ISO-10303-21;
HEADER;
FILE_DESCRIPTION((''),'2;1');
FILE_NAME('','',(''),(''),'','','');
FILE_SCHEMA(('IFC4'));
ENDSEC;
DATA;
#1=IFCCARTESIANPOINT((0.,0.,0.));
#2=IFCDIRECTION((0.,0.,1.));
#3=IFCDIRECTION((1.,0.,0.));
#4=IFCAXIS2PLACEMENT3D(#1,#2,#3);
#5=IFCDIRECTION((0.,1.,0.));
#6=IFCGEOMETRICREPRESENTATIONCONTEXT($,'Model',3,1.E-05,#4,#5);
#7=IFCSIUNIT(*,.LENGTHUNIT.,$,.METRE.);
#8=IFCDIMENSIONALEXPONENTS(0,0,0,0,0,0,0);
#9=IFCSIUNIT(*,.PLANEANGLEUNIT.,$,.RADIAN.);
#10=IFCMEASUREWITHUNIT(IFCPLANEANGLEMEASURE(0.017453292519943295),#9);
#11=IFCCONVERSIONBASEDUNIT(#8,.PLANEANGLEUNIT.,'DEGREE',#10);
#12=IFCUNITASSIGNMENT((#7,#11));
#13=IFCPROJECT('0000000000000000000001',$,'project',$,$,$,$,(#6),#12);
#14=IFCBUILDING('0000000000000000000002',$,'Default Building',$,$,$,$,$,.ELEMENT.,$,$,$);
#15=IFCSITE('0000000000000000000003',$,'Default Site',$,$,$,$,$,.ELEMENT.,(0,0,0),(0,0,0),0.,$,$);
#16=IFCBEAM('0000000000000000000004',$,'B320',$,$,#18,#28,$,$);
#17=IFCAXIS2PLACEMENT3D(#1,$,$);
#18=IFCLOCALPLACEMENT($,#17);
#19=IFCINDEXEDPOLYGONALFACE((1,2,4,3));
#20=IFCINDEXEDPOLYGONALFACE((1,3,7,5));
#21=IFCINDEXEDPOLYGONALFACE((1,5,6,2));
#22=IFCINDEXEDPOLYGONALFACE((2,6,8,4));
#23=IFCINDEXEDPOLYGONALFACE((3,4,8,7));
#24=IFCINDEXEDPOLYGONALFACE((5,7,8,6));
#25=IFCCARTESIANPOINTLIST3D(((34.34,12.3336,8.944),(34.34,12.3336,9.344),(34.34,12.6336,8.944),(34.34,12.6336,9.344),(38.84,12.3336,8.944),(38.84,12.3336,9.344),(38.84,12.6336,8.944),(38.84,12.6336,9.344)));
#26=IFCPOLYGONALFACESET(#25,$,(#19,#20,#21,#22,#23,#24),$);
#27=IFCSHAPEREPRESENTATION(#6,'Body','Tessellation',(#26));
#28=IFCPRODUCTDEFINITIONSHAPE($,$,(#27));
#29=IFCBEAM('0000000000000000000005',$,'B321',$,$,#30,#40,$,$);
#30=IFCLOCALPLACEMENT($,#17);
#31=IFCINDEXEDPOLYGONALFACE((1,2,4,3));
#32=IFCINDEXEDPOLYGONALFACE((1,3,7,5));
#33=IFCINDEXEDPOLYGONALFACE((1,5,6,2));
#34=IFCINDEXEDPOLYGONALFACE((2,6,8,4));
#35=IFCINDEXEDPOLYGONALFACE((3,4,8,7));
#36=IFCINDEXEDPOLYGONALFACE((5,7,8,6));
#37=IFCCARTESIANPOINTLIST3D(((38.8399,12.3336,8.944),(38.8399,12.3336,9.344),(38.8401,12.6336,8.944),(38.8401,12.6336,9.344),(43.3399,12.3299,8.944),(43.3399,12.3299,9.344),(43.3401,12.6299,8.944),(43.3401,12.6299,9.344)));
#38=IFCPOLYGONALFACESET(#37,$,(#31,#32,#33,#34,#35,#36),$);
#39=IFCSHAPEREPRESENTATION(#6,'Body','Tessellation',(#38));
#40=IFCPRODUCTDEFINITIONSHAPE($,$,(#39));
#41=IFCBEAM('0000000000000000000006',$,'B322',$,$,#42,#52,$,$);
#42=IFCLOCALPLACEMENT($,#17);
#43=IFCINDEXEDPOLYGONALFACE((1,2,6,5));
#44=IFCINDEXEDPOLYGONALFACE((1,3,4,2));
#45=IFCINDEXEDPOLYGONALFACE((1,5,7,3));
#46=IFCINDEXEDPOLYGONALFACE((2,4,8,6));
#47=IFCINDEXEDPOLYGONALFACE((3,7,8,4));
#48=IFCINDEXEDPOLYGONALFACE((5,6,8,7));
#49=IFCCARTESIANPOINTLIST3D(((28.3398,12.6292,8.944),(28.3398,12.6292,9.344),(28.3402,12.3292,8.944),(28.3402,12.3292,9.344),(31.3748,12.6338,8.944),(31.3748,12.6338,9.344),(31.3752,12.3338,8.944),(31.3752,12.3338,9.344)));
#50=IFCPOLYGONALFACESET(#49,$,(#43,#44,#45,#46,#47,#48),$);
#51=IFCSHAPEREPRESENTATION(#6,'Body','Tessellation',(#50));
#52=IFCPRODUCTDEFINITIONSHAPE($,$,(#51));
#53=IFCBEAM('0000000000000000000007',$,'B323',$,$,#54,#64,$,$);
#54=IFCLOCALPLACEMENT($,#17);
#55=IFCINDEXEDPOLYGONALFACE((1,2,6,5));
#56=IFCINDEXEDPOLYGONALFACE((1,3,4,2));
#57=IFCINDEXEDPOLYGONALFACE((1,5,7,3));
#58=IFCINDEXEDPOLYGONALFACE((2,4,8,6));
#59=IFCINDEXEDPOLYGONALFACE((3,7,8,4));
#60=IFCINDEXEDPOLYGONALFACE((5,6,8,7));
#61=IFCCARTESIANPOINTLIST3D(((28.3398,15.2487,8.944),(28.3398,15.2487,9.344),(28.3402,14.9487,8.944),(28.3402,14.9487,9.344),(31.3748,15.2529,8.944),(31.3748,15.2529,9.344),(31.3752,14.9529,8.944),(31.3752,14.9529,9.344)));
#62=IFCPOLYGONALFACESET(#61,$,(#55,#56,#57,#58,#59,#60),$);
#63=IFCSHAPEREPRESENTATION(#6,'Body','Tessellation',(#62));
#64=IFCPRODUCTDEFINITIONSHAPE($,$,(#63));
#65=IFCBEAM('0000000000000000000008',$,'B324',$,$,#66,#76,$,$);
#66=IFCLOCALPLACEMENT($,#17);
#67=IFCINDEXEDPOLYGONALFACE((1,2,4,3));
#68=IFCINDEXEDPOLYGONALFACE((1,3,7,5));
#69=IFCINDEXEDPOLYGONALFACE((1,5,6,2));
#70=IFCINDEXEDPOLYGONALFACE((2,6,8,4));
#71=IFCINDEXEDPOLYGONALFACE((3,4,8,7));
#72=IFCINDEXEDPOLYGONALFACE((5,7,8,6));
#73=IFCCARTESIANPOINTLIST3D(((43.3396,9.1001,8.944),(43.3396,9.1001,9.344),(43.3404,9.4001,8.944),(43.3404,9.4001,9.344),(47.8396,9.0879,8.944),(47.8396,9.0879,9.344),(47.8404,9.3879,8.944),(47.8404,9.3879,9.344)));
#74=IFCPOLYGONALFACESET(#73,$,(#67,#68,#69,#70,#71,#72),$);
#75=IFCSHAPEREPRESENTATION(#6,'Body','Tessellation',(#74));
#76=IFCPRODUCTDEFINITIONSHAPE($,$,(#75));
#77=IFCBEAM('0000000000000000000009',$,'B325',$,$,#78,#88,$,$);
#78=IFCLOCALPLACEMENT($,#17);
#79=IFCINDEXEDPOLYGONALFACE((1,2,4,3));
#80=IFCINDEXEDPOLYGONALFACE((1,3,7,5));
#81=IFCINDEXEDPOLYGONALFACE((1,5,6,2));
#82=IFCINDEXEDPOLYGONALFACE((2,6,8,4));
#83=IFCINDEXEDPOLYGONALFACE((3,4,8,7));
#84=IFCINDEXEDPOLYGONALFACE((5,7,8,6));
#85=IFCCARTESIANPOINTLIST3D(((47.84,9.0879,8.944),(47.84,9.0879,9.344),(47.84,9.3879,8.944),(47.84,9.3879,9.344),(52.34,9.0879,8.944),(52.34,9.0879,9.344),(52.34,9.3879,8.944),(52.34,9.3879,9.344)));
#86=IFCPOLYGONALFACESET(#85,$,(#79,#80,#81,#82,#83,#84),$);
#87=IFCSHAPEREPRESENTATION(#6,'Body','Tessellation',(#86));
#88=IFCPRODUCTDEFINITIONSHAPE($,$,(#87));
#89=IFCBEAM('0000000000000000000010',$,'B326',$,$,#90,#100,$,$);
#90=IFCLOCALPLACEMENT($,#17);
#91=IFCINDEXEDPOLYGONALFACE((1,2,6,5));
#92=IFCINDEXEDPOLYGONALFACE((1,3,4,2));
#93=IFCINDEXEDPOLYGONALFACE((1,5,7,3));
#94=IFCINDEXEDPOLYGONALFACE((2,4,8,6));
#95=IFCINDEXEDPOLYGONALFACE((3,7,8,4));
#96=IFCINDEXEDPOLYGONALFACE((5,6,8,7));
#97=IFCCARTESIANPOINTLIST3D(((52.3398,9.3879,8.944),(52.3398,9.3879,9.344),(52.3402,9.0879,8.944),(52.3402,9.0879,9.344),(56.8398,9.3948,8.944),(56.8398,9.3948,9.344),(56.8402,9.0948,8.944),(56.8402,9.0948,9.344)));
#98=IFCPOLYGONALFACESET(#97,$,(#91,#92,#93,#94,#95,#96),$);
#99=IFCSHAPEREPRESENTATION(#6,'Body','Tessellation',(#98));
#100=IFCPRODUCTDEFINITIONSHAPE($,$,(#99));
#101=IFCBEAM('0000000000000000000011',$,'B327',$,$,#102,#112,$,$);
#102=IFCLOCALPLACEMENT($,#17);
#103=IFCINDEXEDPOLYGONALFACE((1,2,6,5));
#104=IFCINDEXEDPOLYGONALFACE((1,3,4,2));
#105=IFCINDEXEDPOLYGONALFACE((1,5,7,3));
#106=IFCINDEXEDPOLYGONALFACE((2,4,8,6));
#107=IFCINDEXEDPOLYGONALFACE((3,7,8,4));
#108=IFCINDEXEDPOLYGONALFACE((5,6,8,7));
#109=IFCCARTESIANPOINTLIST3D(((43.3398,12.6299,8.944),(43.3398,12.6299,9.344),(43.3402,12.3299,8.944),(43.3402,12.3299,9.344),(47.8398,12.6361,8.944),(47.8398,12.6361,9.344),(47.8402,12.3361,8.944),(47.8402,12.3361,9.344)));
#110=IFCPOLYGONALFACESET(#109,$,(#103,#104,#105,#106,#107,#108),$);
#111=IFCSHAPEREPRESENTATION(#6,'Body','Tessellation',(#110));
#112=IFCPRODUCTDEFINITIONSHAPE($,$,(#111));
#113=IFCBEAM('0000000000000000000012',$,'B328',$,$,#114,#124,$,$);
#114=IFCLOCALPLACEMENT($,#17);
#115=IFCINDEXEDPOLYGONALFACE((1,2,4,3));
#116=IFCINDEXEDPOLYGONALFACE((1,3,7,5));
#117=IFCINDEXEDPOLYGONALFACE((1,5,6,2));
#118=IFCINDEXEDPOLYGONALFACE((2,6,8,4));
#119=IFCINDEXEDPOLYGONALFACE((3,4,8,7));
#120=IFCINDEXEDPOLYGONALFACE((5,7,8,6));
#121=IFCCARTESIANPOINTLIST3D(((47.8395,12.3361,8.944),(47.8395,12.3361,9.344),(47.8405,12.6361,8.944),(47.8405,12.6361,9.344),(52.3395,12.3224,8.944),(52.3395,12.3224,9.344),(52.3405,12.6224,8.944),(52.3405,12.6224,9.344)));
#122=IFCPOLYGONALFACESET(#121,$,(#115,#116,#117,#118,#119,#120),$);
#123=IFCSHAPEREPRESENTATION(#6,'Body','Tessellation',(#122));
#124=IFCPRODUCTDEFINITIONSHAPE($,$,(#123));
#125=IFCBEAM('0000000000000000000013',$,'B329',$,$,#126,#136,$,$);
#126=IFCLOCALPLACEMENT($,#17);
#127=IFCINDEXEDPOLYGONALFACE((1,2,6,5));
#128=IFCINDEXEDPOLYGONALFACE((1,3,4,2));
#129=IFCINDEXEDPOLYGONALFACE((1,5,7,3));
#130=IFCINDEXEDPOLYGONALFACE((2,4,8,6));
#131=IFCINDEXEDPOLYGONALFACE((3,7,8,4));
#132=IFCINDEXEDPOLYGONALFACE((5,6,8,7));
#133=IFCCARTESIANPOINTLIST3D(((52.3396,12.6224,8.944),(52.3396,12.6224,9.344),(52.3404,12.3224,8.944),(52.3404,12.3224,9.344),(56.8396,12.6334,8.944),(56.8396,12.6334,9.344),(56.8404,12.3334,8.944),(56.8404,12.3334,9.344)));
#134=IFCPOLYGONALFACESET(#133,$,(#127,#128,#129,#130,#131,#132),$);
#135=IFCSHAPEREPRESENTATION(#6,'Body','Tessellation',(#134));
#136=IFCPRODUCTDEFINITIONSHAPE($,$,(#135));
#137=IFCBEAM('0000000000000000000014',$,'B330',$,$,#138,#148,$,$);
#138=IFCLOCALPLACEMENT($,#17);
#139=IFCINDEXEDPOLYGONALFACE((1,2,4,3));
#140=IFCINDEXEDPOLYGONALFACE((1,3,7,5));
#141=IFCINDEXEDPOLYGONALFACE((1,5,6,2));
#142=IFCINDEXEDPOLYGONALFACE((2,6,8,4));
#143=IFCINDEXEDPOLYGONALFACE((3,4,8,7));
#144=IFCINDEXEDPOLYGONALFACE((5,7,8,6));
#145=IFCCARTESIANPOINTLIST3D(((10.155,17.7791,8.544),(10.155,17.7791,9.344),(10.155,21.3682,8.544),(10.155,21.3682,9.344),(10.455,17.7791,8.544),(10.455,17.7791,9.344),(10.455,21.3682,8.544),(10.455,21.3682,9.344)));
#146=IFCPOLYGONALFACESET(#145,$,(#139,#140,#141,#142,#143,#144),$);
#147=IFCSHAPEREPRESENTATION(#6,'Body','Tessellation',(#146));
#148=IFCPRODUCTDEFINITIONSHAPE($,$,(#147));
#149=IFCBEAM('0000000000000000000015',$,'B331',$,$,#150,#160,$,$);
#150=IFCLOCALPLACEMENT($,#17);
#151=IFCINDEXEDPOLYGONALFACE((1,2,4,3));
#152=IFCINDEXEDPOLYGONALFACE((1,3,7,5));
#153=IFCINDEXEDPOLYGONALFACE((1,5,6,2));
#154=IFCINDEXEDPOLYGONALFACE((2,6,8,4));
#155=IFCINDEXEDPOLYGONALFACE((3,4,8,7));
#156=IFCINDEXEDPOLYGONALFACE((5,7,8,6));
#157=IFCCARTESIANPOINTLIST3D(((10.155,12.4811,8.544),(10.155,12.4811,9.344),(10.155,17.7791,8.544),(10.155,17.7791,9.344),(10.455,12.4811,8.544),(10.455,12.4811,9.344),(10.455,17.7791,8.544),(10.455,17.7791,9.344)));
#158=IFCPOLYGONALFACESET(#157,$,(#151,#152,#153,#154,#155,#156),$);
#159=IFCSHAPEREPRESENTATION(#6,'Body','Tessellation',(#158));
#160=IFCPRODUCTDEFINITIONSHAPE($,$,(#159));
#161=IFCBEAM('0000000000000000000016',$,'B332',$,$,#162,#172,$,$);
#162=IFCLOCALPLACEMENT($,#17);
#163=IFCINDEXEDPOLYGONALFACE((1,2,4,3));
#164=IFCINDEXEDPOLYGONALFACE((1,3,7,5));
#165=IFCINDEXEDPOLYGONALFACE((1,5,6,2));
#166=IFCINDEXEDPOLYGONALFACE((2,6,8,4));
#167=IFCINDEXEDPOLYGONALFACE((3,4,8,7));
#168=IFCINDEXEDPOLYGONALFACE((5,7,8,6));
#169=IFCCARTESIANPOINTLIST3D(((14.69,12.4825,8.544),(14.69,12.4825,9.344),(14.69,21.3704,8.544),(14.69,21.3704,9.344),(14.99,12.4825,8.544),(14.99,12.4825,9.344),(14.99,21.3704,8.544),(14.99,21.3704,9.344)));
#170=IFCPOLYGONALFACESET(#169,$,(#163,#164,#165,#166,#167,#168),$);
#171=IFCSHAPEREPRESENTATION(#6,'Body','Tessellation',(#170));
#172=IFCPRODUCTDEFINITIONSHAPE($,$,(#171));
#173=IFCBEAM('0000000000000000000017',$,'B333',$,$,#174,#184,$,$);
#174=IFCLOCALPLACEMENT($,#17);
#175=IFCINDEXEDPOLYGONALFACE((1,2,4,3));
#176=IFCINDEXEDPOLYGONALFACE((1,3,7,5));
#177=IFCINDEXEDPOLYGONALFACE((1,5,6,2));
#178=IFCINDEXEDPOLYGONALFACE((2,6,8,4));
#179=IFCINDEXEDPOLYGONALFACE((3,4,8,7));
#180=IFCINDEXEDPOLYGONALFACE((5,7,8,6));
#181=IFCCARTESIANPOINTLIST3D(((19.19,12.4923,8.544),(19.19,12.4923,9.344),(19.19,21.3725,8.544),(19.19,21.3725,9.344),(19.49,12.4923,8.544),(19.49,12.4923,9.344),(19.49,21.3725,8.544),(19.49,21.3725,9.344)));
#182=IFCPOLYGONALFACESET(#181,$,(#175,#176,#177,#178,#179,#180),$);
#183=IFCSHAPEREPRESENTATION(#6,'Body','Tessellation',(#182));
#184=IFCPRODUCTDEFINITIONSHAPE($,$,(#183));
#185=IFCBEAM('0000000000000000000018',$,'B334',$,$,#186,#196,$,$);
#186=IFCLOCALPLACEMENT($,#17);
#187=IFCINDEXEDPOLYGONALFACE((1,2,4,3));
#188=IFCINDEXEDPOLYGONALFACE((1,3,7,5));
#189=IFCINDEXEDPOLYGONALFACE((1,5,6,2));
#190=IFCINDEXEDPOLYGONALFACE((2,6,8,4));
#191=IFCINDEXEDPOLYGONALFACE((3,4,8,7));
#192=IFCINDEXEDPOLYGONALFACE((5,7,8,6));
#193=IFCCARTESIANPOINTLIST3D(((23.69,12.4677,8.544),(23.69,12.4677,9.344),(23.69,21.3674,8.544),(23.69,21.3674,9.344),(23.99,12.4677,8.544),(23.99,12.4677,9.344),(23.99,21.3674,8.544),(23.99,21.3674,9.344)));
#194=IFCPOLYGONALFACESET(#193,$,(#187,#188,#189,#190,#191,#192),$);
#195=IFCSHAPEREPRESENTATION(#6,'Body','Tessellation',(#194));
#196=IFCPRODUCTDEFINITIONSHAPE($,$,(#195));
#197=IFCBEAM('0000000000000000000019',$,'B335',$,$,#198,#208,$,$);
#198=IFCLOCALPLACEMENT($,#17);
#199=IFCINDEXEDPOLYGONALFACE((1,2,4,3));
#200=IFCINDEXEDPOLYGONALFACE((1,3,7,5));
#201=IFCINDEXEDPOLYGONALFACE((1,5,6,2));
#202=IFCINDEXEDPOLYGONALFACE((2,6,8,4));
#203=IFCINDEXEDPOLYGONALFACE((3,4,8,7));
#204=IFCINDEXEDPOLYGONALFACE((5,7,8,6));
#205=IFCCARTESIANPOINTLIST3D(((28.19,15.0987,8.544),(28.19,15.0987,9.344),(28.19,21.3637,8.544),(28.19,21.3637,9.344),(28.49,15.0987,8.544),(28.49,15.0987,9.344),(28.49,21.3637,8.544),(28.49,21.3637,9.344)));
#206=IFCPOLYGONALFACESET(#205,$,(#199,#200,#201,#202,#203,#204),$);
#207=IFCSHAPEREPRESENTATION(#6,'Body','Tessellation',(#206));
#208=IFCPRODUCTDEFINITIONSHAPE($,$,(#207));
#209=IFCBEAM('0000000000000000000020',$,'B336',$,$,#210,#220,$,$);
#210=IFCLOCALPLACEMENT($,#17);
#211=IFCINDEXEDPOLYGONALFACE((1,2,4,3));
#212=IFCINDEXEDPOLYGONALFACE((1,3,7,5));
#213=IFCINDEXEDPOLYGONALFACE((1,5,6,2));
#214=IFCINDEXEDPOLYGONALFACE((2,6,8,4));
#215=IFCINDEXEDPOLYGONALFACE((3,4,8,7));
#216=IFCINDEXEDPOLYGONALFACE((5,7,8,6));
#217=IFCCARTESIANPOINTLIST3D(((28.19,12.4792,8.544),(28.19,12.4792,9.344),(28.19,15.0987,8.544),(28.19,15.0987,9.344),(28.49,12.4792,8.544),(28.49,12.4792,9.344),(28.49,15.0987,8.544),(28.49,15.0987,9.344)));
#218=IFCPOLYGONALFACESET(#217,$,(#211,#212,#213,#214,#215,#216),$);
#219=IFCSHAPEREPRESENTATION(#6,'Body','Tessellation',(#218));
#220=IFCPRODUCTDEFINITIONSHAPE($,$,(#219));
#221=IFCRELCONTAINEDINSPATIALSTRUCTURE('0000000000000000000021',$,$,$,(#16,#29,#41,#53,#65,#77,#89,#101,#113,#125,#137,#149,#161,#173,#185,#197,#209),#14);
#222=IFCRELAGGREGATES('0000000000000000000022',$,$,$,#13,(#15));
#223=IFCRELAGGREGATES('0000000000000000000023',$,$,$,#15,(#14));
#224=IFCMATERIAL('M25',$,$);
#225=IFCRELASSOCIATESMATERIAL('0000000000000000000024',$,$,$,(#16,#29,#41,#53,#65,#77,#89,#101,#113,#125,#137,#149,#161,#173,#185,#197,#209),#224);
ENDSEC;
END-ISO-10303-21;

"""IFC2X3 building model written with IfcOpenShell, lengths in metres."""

from ifc_helpers import new_model, entity, si_unit, converted_unit, direction, frame, frame_2d, origin_with_axes, place, context, project, spatial, rectangle, extrude, material, element, save


model = new_model("IFC2X3")

# Units and contexts
model_context = context("Model", 3, precision=1e-05, world=origin_with_axes(), true_north=direction((0.0, 1.0, 0.0)))
ifc_project = project(units=[si_unit("LENGTHUNIT", "METRE"), converted_unit("PLANEANGLEUNIT", "DEGREE", entity("IfcPlaneAngleMeasure", 0.017453292519943295), si_unit("PLANEANGLEUNIT", "RADIAN"), dimensions=[0, 0, 0, 0, 0, 0, 0])], contexts=[model_context])

# Site, building
site = spatial("IfcSite", under=ifc_project, Name="Default Site", CompositionType="ELEMENT", RefLatitude=(0, 0, 0), RefLongitude=(0, 0, 0), RefElevation=0.0)
building = spatial("IfcBuilding", under=site, Name="Default Building", CompositionType="ELEMENT")

# Beams
ifc_material = material(Name="M25")
placement = place(None, origin_with_axes())
element("IfcBeam", 1, at=placement, inside=building, material=ifc_material, Name="B320", context=model_context, shape_type="SweptSolid", body=[
    extrude(rectangle(XDim=0.3, YDim=0.4, at=frame_2d((0.0, 0.0), x_axis=(0.0, 1.0, 0.0))), frame((34.34, 12.4836, 9.144), z_axis=(1.0, -0.000008, 0.0), x_axis=(0.0, 0.0, -1.0)), (0.0, 0.0, 1.0), 4.5),
])
element("IfcBeam", 2, at=placement, inside=building, material=ifc_material, Name="B321", context=model_context, shape_type="SweptSolid", body=[
    extrude(rectangle(XDim=0.3, YDim=0.4, at=frame_2d((0.0, 0.0), x_axis=(0.0, 1.0, 0.0))), frame((38.84, 12.4836, 9.144), z_axis=(1.0, -0.000826, 0.0), x_axis=(0.0, 0.0, -1.0)), (0.0, 0.0, 1.0), 4.5),
])
element("IfcBeam", 3, at=placement, inside=building, material=ifc_material, Name="B322", context=model_context, shape_type="SweptSolid", body=[
    extrude(rectangle(XDim=0.3, YDim=0.4, at=frame_2d((0.0, 0.0), x_axis=(0.0, 1.0, 0.0))), frame((28.34, 12.4792, 9.144), z_axis=(0.999999, 0.001542, 0.0), x_axis=(0.0, 0.0, -1.0)), (0.0, 0.0, 1.0), 3.035),
])
element("IfcBeam", 4, at=placement, inside=building, material=ifc_material, Name="B323", context=model_context, shape_type="SweptSolid", body=[
    extrude(rectangle(XDim=0.3, YDim=0.4, at=frame_2d((0.0, 0.0), x_axis=(0.0, 1.0, 0.0))), frame((31.375, 15.1029, 9.144), z_axis=(-0.999999, -0.001391, 0.0), x_axis=(0.0, 0.0, -1.0)), (0.0, 0.0, 1.0), 3.035),
])
element("IfcBeam", 5, at=placement, inside=building, material=ifc_material, Name="B324", context=model_context, shape_type="SweptSolid", body=[
    extrude(rectangle(XDim=0.3, YDim=0.4, at=frame_2d((0.0, 0.0), x_axis=(0.0, 1.0, 0.0))), frame((43.34, 9.2501, 9.144), z_axis=(0.999996, -0.002702, 0.0), x_axis=(0.0, 0.0, -1.0)), (0.0, 0.0, 1.0), 4.5),
])
element("IfcBeam", 6, at=placement, inside=building, material=ifc_material, Name="B325", context=model_context, shape_type="SweptSolid", body=[
    extrude(rectangle(XDim=0.3, YDim=0.4, at=frame_2d((0.0, 0.0), x_axis=(0.0, 1.0, 0.0))), frame((47.84, 9.2379, 9.144), z_axis=(1.0, 0.0, 0.0), x_axis=(0.0, 0.0, -1.0)), (0.0, 0.0, 1.0), 4.5),
])
element("IfcBeam", 7, at=placement, inside=building, material=ifc_material, Name="B326", context=model_context, shape_type="SweptSolid", body=[
    extrude(rectangle(XDim=0.3, YDim=0.4, at=frame_2d((0.0, 0.0), x_axis=(0.0, 1.0, 0.0))), frame((52.34, 9.2379, 9.144), z_axis=(0.999999, 0.001537, 0.0), x_axis=(0.0, 0.0, -1.0)), (0.0, 0.0, 1.0), 4.5),
])
element("IfcBeam", 8, at=placement, inside=building, material=ifc_material, Name="B327", context=model_context, shape_type="SweptSolid", body=[
    extrude(rectangle(XDim=0.3, YDim=0.4, at=frame_2d((0.0, 0.0), x_axis=(0.0, 1.0, 0.0))), frame((43.34, 12.4799, 9.144), z_axis=(0.999999, 0.001374, 0.0), x_axis=(0.0, 0.0, -1.0)), (0.0, 0.0, 1.0), 4.5),
])
element("IfcBeam", 9, at=placement, inside=building, material=ifc_material, Name="B328", context=model_context, shape_type="SweptSolid", body=[
    extrude(rectangle(XDim=0.3, YDim=0.4, at=frame_2d((0.0, 0.0), x_axis=(0.0, 1.0, 0.0))), frame((47.84, 12.4861, 9.144), z_axis=(0.999995, -0.003045, 0.0), x_axis=(0.0, 0.0, -1.0)), (0.0, 0.0, 1.0), 4.5),
])
element("IfcBeam", 10, at=placement, inside=building, material=ifc_material, Name="B329", context=model_context, shape_type="SweptSolid", body=[
    extrude(rectangle(XDim=0.3, YDim=0.4, at=frame_2d((0.0, 0.0), x_axis=(0.0, 1.0, 0.0))), frame((52.34, 12.4724, 9.144), z_axis=(0.999997, 0.002456, 0.0), x_axis=(0.0, 0.0, -1.0)), (0.0, 0.0, 1.0), 4.5),
])
element("IfcBeam", 11, at=placement, inside=building, material=ifc_material, Name="B330", context=model_context, shape_type="SweptSolid", body=[
    extrude(rectangle(XDim=0.3, YDim=0.8, at=frame_2d((0.0, 0.0), x_axis=(0.0, 1.0, 0.0))), frame((10.305, 21.3682, 8.944), z_axis=(0.0, -1.0, 0.0), x_axis=(0.0, 0.0, -1.0)), (0.0, 0.0, 1.0), 3.5891),
])
element("IfcBeam", 12, at=placement, inside=building, material=ifc_material, Name="B331", context=model_context, shape_type="SweptSolid", body=[
    extrude(rectangle(XDim=0.3, YDim=0.8, at=frame_2d((0.0, 0.0), x_axis=(0.0, 1.0, 0.0))), frame((10.305, 17.7791, 8.944), z_axis=(0.0, -1.0, 0.0), x_axis=(0.0, 0.0, -1.0)), (0.0, 0.0, 1.0), 5.298),
])
element("IfcBeam", 13, at=placement, inside=building, material=ifc_material, Name="B332", context=model_context, shape_type="SweptSolid", body=[
    extrude(rectangle(XDim=0.3, YDim=0.8, at=frame_2d((0.0, 0.0), x_axis=(0.0, 1.0, 0.0))), frame((14.84, 21.3704, 8.944), z_axis=(0.0, -1.0, 0.0), x_axis=(0.0, 0.0, -1.0)), (0.0, 0.0, 1.0), 8.8879),
])
element("IfcBeam", 14, at=placement, inside=building, material=ifc_material, Name="B333", context=model_context, shape_type="SweptSolid", body=[
    extrude(rectangle(XDim=0.3, YDim=0.8, at=frame_2d((0.0, 0.0), x_axis=(0.0, 1.0, 0.0))), frame((19.34, 21.3725, 8.944), z_axis=(0.0, -1.0, 0.0), x_axis=(0.0, 0.0, -1.0)), (0.0, 0.0, 1.0), 8.8802),
])
element("IfcBeam", 15, at=placement, inside=building, material=ifc_material, Name="B334", context=model_context, shape_type="SweptSolid", body=[
    extrude(rectangle(XDim=0.3, YDim=0.8, at=frame_2d((0.0, 0.0), x_axis=(0.0, 1.0, 0.0))), frame((23.84, 21.3674, 8.944), z_axis=(0.0, -1.0, 0.0), x_axis=(0.0, 0.0, -1.0)), (0.0, 0.0, 1.0), 8.8997),
])
element("IfcBeam", 16, at=placement, inside=building, material=ifc_material, Name="B335", context=model_context, shape_type="SweptSolid", body=[
    extrude(rectangle(XDim=0.3, YDim=0.8, at=frame_2d((0.0, 0.0), x_axis=(0.0, 1.0, 0.0))), frame((28.34, 21.3637, 8.944), z_axis=(0.0, -1.0, 0.0), x_axis=(0.0, 0.0, -1.0)), (0.0, 0.0, 1.0), 6.265),
])
element("IfcBeam", 17, at=placement, inside=building, material=ifc_material, Name="B336", context=model_context, shape_type="SweptSolid", body=[
    extrude(rectangle(XDim=0.3, YDim=0.8, at=frame_2d((0.0, 0.0), x_axis=(0.0, 1.0, 0.0))), frame((28.34, 15.0987, 8.944), z_axis=(0.0, -1.0, 0.0), x_axis=(0.0, 0.0, -1.0)), (0.0, 0.0, 1.0), 2.6195),
])

save(model, "model.ifc")
